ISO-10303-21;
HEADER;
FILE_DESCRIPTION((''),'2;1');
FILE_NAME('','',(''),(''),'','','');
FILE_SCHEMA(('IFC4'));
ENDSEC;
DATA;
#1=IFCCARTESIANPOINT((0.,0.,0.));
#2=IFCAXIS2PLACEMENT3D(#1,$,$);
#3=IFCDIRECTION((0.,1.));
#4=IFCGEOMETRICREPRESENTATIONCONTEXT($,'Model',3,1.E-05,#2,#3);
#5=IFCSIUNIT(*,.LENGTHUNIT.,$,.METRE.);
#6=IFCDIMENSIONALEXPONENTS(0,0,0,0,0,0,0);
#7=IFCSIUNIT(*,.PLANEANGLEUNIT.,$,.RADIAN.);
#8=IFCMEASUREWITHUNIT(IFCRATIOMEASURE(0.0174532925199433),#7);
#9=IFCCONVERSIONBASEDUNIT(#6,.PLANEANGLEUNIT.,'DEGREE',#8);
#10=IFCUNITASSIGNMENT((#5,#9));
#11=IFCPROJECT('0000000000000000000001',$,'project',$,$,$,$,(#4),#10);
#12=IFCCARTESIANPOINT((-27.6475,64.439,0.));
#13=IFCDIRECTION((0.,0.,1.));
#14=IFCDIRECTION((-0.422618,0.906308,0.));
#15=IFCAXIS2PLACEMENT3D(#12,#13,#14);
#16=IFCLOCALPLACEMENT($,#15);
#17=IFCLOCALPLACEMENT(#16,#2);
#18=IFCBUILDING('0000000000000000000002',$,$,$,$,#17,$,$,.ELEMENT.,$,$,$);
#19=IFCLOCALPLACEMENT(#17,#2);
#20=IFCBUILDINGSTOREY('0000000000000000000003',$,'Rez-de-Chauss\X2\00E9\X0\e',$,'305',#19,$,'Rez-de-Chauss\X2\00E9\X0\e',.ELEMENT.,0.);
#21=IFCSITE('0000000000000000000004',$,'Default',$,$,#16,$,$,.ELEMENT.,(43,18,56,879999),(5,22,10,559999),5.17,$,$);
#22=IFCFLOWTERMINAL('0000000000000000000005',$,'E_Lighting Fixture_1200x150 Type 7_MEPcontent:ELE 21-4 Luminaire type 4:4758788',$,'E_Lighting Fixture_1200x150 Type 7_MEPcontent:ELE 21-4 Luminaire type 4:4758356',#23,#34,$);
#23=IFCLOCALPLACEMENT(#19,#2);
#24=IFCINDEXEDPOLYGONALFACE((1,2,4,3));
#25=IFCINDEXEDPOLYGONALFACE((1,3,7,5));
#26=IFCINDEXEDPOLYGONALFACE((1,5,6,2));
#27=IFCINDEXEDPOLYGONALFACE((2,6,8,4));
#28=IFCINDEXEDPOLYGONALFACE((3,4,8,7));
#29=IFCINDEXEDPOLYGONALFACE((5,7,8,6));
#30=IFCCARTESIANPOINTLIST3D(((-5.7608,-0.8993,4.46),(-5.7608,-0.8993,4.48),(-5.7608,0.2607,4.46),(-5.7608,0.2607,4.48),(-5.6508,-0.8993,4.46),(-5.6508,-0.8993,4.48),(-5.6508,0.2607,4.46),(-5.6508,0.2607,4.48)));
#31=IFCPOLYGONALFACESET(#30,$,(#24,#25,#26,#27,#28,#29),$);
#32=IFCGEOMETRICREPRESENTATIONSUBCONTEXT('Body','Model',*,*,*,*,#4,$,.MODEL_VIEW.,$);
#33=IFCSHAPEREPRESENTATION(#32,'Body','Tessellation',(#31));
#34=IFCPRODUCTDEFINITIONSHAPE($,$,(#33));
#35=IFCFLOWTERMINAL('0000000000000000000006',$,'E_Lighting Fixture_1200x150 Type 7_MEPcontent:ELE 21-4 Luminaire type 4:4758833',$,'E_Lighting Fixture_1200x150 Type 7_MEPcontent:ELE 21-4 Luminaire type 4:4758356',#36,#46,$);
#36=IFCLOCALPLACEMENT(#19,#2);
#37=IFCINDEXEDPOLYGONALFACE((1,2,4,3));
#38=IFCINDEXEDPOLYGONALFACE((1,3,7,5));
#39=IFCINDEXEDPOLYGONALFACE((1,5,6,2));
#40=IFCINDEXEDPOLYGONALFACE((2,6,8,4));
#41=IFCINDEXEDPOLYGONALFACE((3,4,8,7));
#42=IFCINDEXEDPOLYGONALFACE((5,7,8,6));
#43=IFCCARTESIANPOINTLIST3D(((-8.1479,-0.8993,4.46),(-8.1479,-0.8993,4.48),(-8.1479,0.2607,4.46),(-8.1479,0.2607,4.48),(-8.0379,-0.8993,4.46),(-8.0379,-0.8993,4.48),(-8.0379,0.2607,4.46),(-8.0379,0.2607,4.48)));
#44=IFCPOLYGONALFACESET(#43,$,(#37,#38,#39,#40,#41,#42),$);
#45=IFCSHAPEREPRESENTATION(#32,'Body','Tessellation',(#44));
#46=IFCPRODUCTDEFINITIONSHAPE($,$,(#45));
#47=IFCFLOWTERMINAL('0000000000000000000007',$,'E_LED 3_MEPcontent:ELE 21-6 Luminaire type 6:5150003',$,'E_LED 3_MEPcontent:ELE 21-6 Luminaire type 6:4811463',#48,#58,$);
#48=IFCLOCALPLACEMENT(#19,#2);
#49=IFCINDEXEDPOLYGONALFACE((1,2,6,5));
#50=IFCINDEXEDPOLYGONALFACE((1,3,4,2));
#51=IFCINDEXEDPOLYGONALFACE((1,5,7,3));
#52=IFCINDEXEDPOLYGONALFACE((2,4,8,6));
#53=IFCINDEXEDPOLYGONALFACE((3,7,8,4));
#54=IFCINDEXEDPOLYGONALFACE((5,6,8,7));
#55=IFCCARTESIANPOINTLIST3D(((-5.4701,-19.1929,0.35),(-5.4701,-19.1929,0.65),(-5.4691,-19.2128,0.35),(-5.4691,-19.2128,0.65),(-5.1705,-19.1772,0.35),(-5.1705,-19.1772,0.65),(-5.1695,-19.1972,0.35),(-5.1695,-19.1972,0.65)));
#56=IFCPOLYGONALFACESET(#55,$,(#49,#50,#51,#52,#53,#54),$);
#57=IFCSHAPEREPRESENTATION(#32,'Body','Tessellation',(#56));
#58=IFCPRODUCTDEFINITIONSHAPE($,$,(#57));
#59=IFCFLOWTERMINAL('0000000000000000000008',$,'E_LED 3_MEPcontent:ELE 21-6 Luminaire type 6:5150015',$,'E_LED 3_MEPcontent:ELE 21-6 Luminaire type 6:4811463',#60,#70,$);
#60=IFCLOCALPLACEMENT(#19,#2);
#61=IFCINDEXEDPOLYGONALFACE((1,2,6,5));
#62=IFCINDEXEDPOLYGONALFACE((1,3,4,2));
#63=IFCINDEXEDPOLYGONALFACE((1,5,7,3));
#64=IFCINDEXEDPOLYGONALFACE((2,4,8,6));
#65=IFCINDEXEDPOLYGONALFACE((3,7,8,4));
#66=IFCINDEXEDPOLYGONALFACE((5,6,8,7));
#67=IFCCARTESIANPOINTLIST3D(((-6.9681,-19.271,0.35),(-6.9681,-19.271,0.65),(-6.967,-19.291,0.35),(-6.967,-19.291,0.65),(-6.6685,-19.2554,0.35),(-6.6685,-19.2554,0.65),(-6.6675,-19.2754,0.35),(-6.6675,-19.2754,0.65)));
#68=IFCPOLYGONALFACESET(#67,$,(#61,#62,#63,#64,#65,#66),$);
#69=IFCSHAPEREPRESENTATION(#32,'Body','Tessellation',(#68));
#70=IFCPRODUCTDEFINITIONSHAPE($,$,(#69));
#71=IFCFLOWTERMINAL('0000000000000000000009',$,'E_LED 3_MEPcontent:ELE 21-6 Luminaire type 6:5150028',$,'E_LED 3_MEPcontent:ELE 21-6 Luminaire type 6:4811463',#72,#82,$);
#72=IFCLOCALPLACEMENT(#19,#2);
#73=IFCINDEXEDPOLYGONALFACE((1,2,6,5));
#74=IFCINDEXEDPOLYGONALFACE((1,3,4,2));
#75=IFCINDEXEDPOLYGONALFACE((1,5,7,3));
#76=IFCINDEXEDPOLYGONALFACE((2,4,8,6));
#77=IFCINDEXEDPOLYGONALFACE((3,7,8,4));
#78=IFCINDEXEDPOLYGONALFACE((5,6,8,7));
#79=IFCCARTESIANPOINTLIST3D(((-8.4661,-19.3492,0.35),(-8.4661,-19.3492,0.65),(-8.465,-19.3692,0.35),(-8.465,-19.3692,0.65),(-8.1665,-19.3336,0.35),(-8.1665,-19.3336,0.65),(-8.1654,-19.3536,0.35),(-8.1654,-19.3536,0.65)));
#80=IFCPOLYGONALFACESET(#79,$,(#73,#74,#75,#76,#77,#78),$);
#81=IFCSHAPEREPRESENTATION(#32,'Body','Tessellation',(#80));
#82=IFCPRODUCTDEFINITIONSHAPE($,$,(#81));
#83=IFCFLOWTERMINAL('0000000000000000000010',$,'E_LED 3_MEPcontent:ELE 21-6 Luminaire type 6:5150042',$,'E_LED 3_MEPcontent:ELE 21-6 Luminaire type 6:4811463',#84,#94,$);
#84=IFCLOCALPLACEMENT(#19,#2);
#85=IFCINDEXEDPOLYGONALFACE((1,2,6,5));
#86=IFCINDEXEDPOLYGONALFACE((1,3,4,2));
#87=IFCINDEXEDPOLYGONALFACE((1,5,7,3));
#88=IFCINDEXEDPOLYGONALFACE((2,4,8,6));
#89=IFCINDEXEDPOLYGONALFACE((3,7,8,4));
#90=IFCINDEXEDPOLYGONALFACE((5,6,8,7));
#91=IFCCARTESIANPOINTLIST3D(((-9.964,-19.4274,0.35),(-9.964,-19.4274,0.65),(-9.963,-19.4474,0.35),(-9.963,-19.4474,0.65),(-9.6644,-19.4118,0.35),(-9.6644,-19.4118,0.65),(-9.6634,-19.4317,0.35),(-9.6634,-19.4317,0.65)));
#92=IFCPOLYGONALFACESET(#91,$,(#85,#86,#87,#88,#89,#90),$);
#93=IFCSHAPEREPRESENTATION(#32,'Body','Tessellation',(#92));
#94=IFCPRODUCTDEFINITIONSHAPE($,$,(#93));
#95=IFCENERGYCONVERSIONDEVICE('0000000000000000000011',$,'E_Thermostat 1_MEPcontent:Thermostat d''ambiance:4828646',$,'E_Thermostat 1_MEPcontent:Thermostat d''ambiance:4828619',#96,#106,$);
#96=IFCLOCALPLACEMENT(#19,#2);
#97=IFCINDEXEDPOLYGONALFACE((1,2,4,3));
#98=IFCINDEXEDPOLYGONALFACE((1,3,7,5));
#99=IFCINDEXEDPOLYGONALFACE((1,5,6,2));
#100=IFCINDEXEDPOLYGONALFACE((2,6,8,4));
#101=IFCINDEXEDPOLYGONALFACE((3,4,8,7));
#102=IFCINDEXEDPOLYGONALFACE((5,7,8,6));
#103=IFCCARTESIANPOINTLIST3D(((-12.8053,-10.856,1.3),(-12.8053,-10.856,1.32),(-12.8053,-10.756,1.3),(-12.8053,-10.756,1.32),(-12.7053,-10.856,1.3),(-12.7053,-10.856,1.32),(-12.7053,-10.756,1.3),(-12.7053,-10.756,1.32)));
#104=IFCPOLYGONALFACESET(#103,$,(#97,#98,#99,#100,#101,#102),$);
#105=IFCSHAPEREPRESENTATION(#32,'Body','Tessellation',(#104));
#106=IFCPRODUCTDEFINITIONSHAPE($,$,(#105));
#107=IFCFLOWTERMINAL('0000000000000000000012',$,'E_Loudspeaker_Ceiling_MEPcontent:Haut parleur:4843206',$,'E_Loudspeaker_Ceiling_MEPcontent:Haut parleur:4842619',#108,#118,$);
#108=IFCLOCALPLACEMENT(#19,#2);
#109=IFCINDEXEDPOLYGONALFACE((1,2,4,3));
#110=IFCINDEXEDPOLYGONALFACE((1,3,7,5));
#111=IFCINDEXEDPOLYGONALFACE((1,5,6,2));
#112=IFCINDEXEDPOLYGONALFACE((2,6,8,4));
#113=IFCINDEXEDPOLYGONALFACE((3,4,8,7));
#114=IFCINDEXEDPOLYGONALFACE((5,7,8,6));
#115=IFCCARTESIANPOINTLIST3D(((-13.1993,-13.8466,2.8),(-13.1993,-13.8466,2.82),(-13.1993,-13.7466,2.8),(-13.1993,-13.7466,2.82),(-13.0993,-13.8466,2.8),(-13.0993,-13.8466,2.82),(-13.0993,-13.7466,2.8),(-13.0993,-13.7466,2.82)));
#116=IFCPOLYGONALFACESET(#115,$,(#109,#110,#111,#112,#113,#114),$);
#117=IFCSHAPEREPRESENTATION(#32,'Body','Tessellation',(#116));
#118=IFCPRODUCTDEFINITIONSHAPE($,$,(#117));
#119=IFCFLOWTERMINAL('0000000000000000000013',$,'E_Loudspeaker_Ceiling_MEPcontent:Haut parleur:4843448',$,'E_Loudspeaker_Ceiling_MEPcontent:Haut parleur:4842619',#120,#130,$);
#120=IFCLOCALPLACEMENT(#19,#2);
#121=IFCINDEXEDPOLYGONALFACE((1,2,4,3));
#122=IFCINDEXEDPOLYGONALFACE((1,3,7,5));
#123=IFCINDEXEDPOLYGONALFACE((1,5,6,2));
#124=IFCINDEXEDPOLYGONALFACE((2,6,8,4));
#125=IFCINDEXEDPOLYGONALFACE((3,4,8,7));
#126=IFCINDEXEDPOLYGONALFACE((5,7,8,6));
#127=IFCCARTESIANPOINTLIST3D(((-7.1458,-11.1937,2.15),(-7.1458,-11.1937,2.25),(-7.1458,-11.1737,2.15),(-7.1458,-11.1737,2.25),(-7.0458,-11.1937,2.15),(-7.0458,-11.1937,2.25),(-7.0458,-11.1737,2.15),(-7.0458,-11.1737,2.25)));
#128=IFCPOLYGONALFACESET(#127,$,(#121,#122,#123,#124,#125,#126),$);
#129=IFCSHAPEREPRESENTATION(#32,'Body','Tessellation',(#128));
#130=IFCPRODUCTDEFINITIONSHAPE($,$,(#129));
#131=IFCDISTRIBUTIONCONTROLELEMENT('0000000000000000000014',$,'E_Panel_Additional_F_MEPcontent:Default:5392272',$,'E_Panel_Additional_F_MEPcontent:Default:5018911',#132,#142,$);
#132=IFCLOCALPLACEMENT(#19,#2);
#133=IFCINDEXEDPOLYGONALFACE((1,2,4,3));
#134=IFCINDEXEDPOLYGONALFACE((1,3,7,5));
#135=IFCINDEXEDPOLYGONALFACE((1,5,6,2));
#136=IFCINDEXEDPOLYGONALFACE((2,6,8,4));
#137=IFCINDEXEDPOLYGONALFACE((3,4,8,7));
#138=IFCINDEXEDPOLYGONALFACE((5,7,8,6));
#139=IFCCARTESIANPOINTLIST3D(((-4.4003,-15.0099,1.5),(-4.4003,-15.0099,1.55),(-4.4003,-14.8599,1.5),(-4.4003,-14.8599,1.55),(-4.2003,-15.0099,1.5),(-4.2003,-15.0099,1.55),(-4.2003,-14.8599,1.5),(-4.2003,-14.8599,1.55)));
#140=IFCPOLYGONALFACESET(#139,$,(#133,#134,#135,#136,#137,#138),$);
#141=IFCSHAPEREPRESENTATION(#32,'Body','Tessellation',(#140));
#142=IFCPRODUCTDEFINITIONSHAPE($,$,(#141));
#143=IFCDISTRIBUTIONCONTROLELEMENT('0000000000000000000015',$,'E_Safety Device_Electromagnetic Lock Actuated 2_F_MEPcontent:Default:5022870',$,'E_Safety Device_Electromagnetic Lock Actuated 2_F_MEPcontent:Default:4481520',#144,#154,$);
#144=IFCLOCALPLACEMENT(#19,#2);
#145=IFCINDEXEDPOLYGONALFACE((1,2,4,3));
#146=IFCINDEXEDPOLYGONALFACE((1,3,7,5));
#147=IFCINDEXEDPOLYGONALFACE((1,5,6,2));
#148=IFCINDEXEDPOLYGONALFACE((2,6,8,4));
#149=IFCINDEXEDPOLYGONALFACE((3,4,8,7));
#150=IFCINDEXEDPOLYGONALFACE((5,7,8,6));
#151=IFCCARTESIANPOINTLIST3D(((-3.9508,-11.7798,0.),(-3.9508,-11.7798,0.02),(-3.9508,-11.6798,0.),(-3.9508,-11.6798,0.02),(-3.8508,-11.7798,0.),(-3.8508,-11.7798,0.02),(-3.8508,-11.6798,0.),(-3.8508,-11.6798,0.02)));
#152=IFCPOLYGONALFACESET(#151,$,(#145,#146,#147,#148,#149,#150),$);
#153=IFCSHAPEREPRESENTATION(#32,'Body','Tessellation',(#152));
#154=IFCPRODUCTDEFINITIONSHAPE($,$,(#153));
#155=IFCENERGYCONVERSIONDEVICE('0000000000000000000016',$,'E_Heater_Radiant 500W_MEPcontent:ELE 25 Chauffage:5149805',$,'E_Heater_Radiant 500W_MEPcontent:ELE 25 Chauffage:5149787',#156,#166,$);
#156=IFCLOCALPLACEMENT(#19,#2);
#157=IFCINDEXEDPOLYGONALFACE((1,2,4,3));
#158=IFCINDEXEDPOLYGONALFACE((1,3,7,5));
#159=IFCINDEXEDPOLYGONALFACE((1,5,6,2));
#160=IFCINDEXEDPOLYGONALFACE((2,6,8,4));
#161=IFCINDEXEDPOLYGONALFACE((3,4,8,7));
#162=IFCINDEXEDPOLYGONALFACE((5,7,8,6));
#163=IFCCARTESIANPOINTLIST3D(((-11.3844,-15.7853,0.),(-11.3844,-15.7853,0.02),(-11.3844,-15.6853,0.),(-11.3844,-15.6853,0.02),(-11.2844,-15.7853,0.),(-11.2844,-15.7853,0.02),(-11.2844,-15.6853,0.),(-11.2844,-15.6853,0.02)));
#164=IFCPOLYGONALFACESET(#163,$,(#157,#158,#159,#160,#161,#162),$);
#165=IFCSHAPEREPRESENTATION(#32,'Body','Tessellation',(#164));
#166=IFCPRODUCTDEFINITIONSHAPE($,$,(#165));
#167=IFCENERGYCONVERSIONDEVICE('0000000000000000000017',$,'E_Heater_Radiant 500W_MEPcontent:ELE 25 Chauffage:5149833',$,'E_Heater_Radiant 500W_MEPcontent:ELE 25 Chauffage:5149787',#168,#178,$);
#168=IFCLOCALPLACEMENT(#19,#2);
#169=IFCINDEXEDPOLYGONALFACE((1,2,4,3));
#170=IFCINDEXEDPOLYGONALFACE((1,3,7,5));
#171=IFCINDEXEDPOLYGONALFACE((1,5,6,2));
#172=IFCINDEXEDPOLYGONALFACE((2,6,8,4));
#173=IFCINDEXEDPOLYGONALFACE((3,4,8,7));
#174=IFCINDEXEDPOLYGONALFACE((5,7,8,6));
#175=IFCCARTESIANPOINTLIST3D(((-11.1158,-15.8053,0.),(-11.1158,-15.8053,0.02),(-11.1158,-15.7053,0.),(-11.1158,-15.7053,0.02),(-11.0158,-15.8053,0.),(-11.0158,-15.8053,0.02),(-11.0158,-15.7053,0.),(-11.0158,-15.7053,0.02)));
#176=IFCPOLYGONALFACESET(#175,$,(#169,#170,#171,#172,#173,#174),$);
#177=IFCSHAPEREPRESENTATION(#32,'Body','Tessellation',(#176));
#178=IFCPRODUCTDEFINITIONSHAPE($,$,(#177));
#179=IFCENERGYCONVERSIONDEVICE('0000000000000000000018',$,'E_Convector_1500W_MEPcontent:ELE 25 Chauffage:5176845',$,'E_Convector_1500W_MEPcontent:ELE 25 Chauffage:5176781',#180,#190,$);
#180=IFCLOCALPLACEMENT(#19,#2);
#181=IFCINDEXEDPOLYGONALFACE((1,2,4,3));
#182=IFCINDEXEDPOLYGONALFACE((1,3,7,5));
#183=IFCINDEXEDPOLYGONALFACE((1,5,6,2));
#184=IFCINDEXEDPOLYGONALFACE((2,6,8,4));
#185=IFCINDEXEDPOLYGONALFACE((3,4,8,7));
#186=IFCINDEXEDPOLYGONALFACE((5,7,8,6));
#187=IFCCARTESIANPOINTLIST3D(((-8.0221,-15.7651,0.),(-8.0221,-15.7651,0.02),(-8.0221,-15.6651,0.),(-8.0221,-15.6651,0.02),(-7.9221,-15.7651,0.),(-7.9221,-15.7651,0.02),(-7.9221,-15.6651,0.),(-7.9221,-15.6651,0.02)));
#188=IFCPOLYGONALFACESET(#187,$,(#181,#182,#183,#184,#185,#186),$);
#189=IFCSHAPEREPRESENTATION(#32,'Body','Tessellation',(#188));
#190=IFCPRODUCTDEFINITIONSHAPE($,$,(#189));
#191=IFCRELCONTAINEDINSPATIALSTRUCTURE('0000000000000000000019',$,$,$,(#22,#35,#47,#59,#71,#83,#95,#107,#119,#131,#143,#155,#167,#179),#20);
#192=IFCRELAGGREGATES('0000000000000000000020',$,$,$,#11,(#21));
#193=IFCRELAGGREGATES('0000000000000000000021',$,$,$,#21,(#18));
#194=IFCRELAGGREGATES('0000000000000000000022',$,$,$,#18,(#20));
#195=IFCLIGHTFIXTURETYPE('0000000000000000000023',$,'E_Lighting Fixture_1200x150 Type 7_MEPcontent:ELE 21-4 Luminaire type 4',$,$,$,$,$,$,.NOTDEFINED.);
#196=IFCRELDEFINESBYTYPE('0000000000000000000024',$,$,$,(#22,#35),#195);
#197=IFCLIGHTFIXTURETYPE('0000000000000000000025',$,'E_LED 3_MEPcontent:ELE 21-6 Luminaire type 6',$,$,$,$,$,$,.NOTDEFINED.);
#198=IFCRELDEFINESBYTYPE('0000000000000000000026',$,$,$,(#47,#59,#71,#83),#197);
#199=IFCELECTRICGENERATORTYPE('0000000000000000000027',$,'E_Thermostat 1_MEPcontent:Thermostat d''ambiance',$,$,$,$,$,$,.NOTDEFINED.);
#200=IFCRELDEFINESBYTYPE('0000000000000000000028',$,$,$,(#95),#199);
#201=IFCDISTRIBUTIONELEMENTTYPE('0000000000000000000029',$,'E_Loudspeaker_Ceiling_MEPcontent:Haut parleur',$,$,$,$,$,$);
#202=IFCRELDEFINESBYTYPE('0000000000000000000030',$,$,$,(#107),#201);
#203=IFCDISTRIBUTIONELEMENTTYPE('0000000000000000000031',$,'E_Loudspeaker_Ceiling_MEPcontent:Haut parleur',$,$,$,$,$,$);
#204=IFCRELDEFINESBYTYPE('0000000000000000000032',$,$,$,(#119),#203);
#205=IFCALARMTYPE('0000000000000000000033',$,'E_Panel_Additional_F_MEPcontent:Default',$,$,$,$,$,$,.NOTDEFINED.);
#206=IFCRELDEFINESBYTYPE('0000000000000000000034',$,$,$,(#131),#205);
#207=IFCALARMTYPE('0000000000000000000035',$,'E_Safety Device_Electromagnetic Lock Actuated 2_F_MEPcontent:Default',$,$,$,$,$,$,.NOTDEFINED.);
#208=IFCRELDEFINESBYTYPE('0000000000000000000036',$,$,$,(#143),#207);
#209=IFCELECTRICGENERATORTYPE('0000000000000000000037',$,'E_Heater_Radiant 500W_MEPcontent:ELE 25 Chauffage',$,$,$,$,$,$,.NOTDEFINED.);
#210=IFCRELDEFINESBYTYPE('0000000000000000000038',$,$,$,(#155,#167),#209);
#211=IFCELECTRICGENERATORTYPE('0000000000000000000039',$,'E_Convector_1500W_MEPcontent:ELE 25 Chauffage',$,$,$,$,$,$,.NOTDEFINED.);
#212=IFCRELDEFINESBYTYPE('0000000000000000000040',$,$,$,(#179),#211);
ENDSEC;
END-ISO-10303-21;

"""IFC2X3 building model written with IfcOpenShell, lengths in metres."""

from ifc_helpers import new_model, entity, si_unit, converted_unit, direction, frame, frame_2d, origin, origin_2d_with_axis, place, context, subcontext, project, spatial, rectangle, extrude, source, transform, mapped, type_object, type_shapes, element, save


model = new_model("IFC2X3")

# Units and contexts
model_context = context("Model", 3, precision=1e-05, world=origin(), true_north=direction((0.0, 1.0)))
body_context = subcontext(model_context, "Body", "Model", "MODEL_VIEW")
ifc_project = project(units=[si_unit("LENGTHUNIT", "METRE"), converted_unit("PLANEANGLEUNIT", "DEGREE", entity("IfcRatioMeasure", 0.0174532925199433), si_unit("PLANEANGLEUNIT", "RADIAN"), dimensions=[0, 0, 0, 0, 0, 0, 0])], contexts=[model_context])

# Site, building, storey
site_placement = place(None, frame((-27.6475, 64.439, 0.0), z_axis=(0.0, 0.0, 1.0), x_axis=(-0.422618, 0.906308, 0.0)))
site = spatial("IfcSite", under=ifc_project, at=site_placement, Name="Default", CompositionType="ELEMENT", RefLatitude=(43, 18, 56, 879999), RefLongitude=(5, 22, 10, 559999), RefElevation=5.17)
building_placement = place(site_placement, origin())
building = spatial("IfcBuilding", under=site, at=building_placement, CompositionType="ELEMENT")
storey_placement = place(building_placement, origin())
storey = spatial("IfcBuildingStorey", under=building, at=storey_placement, Name="Rez-de-Chaussée", ObjectType="305", LongName="Rez-de-Chaussée", CompositionType="ELEMENT", Elevation=0.0)

# Flow terminals
light_fixture_type_1 = type_object("IfcLightFixtureType", Name="E_Lighting Fixture_1200x150 Type 7_MEPcontent:ELE 21-4 Luminaire type 4", PredefinedType="NOTDEFINED")
shared_shape_1 = source(origin(), body_context, "Body", "SweptSolid", [
    extrude(rectangle(XDim=0.11, YDim=1.16, at=origin_2d_with_axis()), frame((0.0, 0.0, 0.0), z_axis=(0.0, 0.0, 1.0), x_axis=(0.0, -1.0, 0.0)), (0.0, 0.0, 1.0), 0.02),
])
type_shapes(light_fixture_type_1, [shared_shape_1])
for number, where, z_axis, x_axis, name in (
    (1, (-5.7058, -0.3193, 4.46), (0.0, 0.0, 1.0), (0.0, -1.0, 0.0), "E_Lighting Fixture_1200x150 Type 7_MEPcontent:ELE 21-4 Luminaire type 4:4758788"),
    (2, (-8.0929, -0.3193, 4.46), (0.0, 0.0, 1.0), (0.0, -1.0, 0.0), "E_Lighting Fixture_1200x150 Type 7_MEPcontent:ELE 21-4 Luminaire type 4:4758833"),
):
    element("IfcFlowTerminal", number, at=place(storey_placement, frame(where, z_axis=z_axis, x_axis=x_axis)), inside=storey, type_object=light_fixture_type_1, Name=name, ObjectType="E_Lighting Fixture_1200x150 Type 7_MEPcontent:ELE 21-4 Luminaire type 4:4758356", context=body_context, shape_type="MappedRepresentation", body=[
        mapped(shared_shape_1, transform((0.0, 0.0, 0.0), scale=1.0)),
    ])
light_fixture_type_2 = type_object("IfcLightFixtureType", Name="E_LED 3_MEPcontent:ELE 21-6 Luminaire type 6", PredefinedType="NOTDEFINED")
shared_shape_2 = source(origin(), body_context, "Body", "SweptSolid", [
    extrude(rectangle(XDim=0.02, YDim=0.3, at=origin_2d_with_axis()), frame((-0.01, 0.0, -0.15)), (0.0, 0.0, 1.0), 0.3),
])
type_shapes(light_fixture_type_2, [shared_shape_2])
for number, where, z_axis, x_axis, name in (
    (3, (-5.3193, -19.205, 0.5), (0.0, 0.0, 1.0), (0.05212, -0.998641, 0.0), "E_LED 3_MEPcontent:ELE 21-6 Luminaire type 6:5150003"),
    (4, (-6.8173, -19.2832, 0.5), (0.0, 0.0, 1.0), (0.05212, -0.998641, 0.0), "E_LED 3_MEPcontent:ELE 21-6 Luminaire type 6:5150015"),
    (5, (-8.3152, -19.3614, 0.5), (0.0, 0.0, 1.0), (0.05212, -0.998641, 0.0), "E_LED 3_MEPcontent:ELE 21-6 Luminaire type 6:5150028"),
    (6, (-9.8132, -19.4396, 0.5), (0.0, 0.0, 1.0), (0.05212, -0.998641, 0.0), "E_LED 3_MEPcontent:ELE 21-6 Luminaire type 6:5150042"),
):
    element("IfcFlowTerminal", number, at=place(storey_placement, frame(where, z_axis=z_axis, x_axis=x_axis)), inside=storey, type_object=light_fixture_type_2, Name=name, ObjectType="E_LED 3_MEPcontent:ELE 21-6 Luminaire type 6:4811463", context=body_context, shape_type="MappedRepresentation", body=[
        mapped(shared_shape_2, transform((0.0, 0.0, 0.0), scale=1.0)),
    ])

# Energy conversion device
electric_generator_type_1 = type_object("IfcElectricGeneratorType", Name="E_Thermostat 1_MEPcontent:Thermostat d'ambiance", PredefinedType="NOTDEFINED")
shared_shape_3 = source(origin(), body_context, "Body", "SweptSolid", [
    extrude(rectangle(XDim=0.1, YDim=0.1, at=origin_2d_with_axis()), frame((0.0, 0.0, 0.0), z_axis=(0.0, 0.0, 1.0), x_axis=(0.0, -1.0, 0.0)), (0.0, 0.0, 1.0), 0.02),
])
type_shapes(electric_generator_type_1, [shared_shape_3])
energy_conversion_device_1_placement = place(storey_placement, frame((-12.7553, -10.806, 1.3), z_axis=(0.0, 0.0, 1.0), x_axis=(0.0, -1.0, 0.0)))
element("IfcEnergyConversionDevice", 7, at=energy_conversion_device_1_placement, inside=storey, type_object=electric_generator_type_1, Name="E_Thermostat 1_MEPcontent:Thermostat d'ambiance:4828646", ObjectType="E_Thermostat 1_MEPcontent:Thermostat d'ambiance:4828619", context=body_context, shape_type="MappedRepresentation", body=[
    mapped(shared_shape_3, transform((0.0, 0.0, 0.0), scale=1.0)),
])

# Flow terminals
distribution_element_type_1 = type_object("IfcDistributionElementType", Name="E_Loudspeaker_Ceiling_MEPcontent:Haut parleur")
shared_shape_4 = source(origin(), body_context, "Body", "SweptSolid", [
    extrude(rectangle(XDim=0.1, YDim=0.1, at=origin_2d_with_axis()), frame((0.0, 0.0, 0.0), z_axis=(0.0, 0.0, 1.0), x_axis=(0.0, -1.0, 0.0)), (0.0, 0.0, 1.0), 0.02),
])
type_shapes(distribution_element_type_1, [shared_shape_4])
flow_terminal_1_placement = place(storey_placement, frame((-13.1493, -13.7966, 2.8), z_axis=(0.0, 0.0, 1.0), x_axis=(0.0, 1.0, 0.0)))
element("IfcFlowTerminal", 8, at=flow_terminal_1_placement, inside=storey, type_object=distribution_element_type_1, Name="E_Loudspeaker_Ceiling_MEPcontent:Haut parleur:4843206", ObjectType="E_Loudspeaker_Ceiling_MEPcontent:Haut parleur:4842619", context=body_context, shape_type="MappedRepresentation", body=[
    mapped(shared_shape_4, transform((0.0, 0.0, 0.0), scale=1.0)),
])
distribution_element_type_2 = type_object("IfcDistributionElementType", Name="E_Loudspeaker_Ceiling_MEPcontent:Haut parleur")
shared_shape_5 = source(origin(), body_context, "Body", "SweptSolid", [
    extrude(rectangle(XDim=0.02, YDim=0.1, at=frame_2d((0.0, 0.0), x_axis=(1.0, 0.0))), frame((0.0, 0.01, -0.05), z_axis=(0.0, 0.0, 1.0), x_axis=(0.0, -1.0, 0.0)), (0.0, 0.0, 1.0), 0.1),
])
type_shapes(distribution_element_type_2, [shared_shape_5])
flow_terminal_2_placement = place(storey_placement, frame((-7.0958, -11.1937, 2.2)))
element("IfcFlowTerminal", 9, at=flow_terminal_2_placement, inside=storey, type_object=distribution_element_type_2, Name="E_Loudspeaker_Ceiling_MEPcontent:Haut parleur:4843448", ObjectType="E_Loudspeaker_Ceiling_MEPcontent:Haut parleur:4842619", context=body_context, shape_type="MappedRepresentation", body=[
    mapped(shared_shape_5, transform((0.0, 0.0, 0.0), scale=1.0)),
])

# Distribution control elements
alarm_type_1 = type_object("IfcAlarmType", Name="E_Panel_Additional_F_MEPcontent:Default", PredefinedType="NOTDEFINED")
shared_shape_6 = source(origin(), body_context, "Body", "SweptSolid", [
    extrude(rectangle(XDim=0.15, YDim=0.05, at=frame_2d((0.0, 0.0), x_axis=(1.0, 0.0))), frame((0.0, 0.025, 0.0)), (0.0, 0.0, 1.0), 0.2),
])
type_shapes(alarm_type_1, [shared_shape_6])
distribution_control_element_1_placement = place(storey_placement, frame((-4.4003, -14.9349, 1.5), z_axis=(1.0, 0.0, 0.0), x_axis=(0.0, 1.0, 0.0)))
element("IfcDistributionControlElement", 10, at=distribution_control_element_1_placement, inside=storey, type_object=alarm_type_1, Name="E_Panel_Additional_F_MEPcontent:Default:5392272", ObjectType="E_Panel_Additional_F_MEPcontent:Default:5018911", context=body_context, shape_type="MappedRepresentation", body=[
    mapped(shared_shape_6, transform((0.0, 0.0, 0.0), scale=1.0)),
])
alarm_type_2 = type_object("IfcAlarmType", Name="E_Safety Device_Electromagnetic Lock Actuated 2_F_MEPcontent:Default", PredefinedType="NOTDEFINED")
shared_shape_7 = source(origin(), body_context, "Body", "SweptSolid", [
    extrude(rectangle(XDim=0.1, YDim=0.1, at=origin_2d_with_axis()), frame((0.0, 0.0, 0.0), z_axis=(0.0, 0.0, 1.0), x_axis=(0.0, 1.0, 0.0)), (0.0, 0.0, 1.0), 0.02),
])
type_shapes(alarm_type_2, [shared_shape_7])
distribution_control_element_2_placement = place(storey_placement, frame((-3.9008, -11.7298, 0.0), z_axis=(0.0, 0.0, 1.0), x_axis=(0.0, -1.0, 0.0)))
element("IfcDistributionControlElement", 11, at=distribution_control_element_2_placement, inside=storey, type_object=alarm_type_2, Name="E_Safety Device_Electromagnetic Lock Actuated 2_F_MEPcontent:Default:5022870", ObjectType="E_Safety Device_Electromagnetic Lock Actuated 2_F_MEPcontent:Default:4481520", context=body_context, shape_type="MappedRepresentation", body=[
    mapped(shared_shape_7, transform((0.0, 0.0, 0.0), scale=1.0)),
])

# Energy conversion devices
electric_generator_type_2 = type_object("IfcElectricGeneratorType", Name="E_Heater_Radiant 500W_MEPcontent:ELE 25 Chauffage", PredefinedType="NOTDEFINED")
shared_shape_8 = source(origin(), body_context, "Body", "SweptSolid", [
    extrude(rectangle(XDim=0.1, YDim=0.1, at=origin_2d_with_axis()), frame((0.0, 0.0, 0.0), z_axis=(0.0, 0.0, 1.0), x_axis=(0.0, -1.0, 0.0)), (0.0, 0.0, 1.0), 0.02),
])
type_shapes(electric_generator_type_2, [shared_shape_8])
energy_conversion_device_2_placement = place(storey_placement, frame((-11.3344, -15.7353, 0.0)))
element("IfcEnergyConversionDevice", 12, at=energy_conversion_device_2_placement, inside=storey, type_object=electric_generator_type_2, Name="E_Heater_Radiant 500W_MEPcontent:ELE 25 Chauffage:5149805", ObjectType="E_Heater_Radiant 500W_MEPcontent:ELE 25 Chauffage:5149787", context=body_context, shape_type="MappedRepresentation", body=[
    mapped(shared_shape_8, transform((0.0, 0.0, 0.0), scale=1.0)),
])
energy_conversion_device_3_placement = place(storey_placement, frame((-11.0658, -15.7553, 0.0), z_axis=(0.0, 0.0, 1.0), x_axis=(-1.0, 0.0, 0.0)))
element("IfcEnergyConversionDevice", 13, at=energy_conversion_device_3_placement, inside=storey, type_object=electric_generator_type_2, Name="E_Heater_Radiant 500W_MEPcontent:ELE 25 Chauffage:5149833", ObjectType="E_Heater_Radiant 500W_MEPcontent:ELE 25 Chauffage:5149787", context=body_context, shape_type="MappedRepresentation", body=[
    mapped(shared_shape_8, transform((0.0, 0.0, 0.0), scale=1.0)),
])
electric_generator_type_3 = type_object("IfcElectricGeneratorType", Name="E_Convector_1500W_MEPcontent:ELE 25 Chauffage", PredefinedType="NOTDEFINED")
shared_shape_9 = source(origin(), body_context, "Body", "SweptSolid", [
    extrude(rectangle(XDim=0.1, YDim=0.1, at=origin_2d_with_axis()), frame((0.0, 0.0, 0.0), z_axis=(0.0, 0.0, 1.0), x_axis=(0.0, -1.0, 0.0)), (0.0, 0.0, 1.0), 0.02),
])
type_shapes(electric_generator_type_3, [shared_shape_9])
energy_conversion_device_4_placement = place(storey_placement, frame((-7.9721, -15.7151, 0.0), z_axis=(0.0, 0.0, 1.0), x_axis=(0.0, -1.0, 0.0)))
element("IfcEnergyConversionDevice", 14, at=energy_conversion_device_4_placement, inside=storey, type_object=electric_generator_type_3, Name="E_Convector_1500W_MEPcontent:ELE 25 Chauffage:5176845", ObjectType="E_Convector_1500W_MEPcontent:ELE 25 Chauffage:5176781", context=body_context, shape_type="MappedRepresentation", body=[
    mapped(shared_shape_9, transform((0.0, 0.0, 0.0), scale=1.0)),
])

save(model, "model.ifc")
